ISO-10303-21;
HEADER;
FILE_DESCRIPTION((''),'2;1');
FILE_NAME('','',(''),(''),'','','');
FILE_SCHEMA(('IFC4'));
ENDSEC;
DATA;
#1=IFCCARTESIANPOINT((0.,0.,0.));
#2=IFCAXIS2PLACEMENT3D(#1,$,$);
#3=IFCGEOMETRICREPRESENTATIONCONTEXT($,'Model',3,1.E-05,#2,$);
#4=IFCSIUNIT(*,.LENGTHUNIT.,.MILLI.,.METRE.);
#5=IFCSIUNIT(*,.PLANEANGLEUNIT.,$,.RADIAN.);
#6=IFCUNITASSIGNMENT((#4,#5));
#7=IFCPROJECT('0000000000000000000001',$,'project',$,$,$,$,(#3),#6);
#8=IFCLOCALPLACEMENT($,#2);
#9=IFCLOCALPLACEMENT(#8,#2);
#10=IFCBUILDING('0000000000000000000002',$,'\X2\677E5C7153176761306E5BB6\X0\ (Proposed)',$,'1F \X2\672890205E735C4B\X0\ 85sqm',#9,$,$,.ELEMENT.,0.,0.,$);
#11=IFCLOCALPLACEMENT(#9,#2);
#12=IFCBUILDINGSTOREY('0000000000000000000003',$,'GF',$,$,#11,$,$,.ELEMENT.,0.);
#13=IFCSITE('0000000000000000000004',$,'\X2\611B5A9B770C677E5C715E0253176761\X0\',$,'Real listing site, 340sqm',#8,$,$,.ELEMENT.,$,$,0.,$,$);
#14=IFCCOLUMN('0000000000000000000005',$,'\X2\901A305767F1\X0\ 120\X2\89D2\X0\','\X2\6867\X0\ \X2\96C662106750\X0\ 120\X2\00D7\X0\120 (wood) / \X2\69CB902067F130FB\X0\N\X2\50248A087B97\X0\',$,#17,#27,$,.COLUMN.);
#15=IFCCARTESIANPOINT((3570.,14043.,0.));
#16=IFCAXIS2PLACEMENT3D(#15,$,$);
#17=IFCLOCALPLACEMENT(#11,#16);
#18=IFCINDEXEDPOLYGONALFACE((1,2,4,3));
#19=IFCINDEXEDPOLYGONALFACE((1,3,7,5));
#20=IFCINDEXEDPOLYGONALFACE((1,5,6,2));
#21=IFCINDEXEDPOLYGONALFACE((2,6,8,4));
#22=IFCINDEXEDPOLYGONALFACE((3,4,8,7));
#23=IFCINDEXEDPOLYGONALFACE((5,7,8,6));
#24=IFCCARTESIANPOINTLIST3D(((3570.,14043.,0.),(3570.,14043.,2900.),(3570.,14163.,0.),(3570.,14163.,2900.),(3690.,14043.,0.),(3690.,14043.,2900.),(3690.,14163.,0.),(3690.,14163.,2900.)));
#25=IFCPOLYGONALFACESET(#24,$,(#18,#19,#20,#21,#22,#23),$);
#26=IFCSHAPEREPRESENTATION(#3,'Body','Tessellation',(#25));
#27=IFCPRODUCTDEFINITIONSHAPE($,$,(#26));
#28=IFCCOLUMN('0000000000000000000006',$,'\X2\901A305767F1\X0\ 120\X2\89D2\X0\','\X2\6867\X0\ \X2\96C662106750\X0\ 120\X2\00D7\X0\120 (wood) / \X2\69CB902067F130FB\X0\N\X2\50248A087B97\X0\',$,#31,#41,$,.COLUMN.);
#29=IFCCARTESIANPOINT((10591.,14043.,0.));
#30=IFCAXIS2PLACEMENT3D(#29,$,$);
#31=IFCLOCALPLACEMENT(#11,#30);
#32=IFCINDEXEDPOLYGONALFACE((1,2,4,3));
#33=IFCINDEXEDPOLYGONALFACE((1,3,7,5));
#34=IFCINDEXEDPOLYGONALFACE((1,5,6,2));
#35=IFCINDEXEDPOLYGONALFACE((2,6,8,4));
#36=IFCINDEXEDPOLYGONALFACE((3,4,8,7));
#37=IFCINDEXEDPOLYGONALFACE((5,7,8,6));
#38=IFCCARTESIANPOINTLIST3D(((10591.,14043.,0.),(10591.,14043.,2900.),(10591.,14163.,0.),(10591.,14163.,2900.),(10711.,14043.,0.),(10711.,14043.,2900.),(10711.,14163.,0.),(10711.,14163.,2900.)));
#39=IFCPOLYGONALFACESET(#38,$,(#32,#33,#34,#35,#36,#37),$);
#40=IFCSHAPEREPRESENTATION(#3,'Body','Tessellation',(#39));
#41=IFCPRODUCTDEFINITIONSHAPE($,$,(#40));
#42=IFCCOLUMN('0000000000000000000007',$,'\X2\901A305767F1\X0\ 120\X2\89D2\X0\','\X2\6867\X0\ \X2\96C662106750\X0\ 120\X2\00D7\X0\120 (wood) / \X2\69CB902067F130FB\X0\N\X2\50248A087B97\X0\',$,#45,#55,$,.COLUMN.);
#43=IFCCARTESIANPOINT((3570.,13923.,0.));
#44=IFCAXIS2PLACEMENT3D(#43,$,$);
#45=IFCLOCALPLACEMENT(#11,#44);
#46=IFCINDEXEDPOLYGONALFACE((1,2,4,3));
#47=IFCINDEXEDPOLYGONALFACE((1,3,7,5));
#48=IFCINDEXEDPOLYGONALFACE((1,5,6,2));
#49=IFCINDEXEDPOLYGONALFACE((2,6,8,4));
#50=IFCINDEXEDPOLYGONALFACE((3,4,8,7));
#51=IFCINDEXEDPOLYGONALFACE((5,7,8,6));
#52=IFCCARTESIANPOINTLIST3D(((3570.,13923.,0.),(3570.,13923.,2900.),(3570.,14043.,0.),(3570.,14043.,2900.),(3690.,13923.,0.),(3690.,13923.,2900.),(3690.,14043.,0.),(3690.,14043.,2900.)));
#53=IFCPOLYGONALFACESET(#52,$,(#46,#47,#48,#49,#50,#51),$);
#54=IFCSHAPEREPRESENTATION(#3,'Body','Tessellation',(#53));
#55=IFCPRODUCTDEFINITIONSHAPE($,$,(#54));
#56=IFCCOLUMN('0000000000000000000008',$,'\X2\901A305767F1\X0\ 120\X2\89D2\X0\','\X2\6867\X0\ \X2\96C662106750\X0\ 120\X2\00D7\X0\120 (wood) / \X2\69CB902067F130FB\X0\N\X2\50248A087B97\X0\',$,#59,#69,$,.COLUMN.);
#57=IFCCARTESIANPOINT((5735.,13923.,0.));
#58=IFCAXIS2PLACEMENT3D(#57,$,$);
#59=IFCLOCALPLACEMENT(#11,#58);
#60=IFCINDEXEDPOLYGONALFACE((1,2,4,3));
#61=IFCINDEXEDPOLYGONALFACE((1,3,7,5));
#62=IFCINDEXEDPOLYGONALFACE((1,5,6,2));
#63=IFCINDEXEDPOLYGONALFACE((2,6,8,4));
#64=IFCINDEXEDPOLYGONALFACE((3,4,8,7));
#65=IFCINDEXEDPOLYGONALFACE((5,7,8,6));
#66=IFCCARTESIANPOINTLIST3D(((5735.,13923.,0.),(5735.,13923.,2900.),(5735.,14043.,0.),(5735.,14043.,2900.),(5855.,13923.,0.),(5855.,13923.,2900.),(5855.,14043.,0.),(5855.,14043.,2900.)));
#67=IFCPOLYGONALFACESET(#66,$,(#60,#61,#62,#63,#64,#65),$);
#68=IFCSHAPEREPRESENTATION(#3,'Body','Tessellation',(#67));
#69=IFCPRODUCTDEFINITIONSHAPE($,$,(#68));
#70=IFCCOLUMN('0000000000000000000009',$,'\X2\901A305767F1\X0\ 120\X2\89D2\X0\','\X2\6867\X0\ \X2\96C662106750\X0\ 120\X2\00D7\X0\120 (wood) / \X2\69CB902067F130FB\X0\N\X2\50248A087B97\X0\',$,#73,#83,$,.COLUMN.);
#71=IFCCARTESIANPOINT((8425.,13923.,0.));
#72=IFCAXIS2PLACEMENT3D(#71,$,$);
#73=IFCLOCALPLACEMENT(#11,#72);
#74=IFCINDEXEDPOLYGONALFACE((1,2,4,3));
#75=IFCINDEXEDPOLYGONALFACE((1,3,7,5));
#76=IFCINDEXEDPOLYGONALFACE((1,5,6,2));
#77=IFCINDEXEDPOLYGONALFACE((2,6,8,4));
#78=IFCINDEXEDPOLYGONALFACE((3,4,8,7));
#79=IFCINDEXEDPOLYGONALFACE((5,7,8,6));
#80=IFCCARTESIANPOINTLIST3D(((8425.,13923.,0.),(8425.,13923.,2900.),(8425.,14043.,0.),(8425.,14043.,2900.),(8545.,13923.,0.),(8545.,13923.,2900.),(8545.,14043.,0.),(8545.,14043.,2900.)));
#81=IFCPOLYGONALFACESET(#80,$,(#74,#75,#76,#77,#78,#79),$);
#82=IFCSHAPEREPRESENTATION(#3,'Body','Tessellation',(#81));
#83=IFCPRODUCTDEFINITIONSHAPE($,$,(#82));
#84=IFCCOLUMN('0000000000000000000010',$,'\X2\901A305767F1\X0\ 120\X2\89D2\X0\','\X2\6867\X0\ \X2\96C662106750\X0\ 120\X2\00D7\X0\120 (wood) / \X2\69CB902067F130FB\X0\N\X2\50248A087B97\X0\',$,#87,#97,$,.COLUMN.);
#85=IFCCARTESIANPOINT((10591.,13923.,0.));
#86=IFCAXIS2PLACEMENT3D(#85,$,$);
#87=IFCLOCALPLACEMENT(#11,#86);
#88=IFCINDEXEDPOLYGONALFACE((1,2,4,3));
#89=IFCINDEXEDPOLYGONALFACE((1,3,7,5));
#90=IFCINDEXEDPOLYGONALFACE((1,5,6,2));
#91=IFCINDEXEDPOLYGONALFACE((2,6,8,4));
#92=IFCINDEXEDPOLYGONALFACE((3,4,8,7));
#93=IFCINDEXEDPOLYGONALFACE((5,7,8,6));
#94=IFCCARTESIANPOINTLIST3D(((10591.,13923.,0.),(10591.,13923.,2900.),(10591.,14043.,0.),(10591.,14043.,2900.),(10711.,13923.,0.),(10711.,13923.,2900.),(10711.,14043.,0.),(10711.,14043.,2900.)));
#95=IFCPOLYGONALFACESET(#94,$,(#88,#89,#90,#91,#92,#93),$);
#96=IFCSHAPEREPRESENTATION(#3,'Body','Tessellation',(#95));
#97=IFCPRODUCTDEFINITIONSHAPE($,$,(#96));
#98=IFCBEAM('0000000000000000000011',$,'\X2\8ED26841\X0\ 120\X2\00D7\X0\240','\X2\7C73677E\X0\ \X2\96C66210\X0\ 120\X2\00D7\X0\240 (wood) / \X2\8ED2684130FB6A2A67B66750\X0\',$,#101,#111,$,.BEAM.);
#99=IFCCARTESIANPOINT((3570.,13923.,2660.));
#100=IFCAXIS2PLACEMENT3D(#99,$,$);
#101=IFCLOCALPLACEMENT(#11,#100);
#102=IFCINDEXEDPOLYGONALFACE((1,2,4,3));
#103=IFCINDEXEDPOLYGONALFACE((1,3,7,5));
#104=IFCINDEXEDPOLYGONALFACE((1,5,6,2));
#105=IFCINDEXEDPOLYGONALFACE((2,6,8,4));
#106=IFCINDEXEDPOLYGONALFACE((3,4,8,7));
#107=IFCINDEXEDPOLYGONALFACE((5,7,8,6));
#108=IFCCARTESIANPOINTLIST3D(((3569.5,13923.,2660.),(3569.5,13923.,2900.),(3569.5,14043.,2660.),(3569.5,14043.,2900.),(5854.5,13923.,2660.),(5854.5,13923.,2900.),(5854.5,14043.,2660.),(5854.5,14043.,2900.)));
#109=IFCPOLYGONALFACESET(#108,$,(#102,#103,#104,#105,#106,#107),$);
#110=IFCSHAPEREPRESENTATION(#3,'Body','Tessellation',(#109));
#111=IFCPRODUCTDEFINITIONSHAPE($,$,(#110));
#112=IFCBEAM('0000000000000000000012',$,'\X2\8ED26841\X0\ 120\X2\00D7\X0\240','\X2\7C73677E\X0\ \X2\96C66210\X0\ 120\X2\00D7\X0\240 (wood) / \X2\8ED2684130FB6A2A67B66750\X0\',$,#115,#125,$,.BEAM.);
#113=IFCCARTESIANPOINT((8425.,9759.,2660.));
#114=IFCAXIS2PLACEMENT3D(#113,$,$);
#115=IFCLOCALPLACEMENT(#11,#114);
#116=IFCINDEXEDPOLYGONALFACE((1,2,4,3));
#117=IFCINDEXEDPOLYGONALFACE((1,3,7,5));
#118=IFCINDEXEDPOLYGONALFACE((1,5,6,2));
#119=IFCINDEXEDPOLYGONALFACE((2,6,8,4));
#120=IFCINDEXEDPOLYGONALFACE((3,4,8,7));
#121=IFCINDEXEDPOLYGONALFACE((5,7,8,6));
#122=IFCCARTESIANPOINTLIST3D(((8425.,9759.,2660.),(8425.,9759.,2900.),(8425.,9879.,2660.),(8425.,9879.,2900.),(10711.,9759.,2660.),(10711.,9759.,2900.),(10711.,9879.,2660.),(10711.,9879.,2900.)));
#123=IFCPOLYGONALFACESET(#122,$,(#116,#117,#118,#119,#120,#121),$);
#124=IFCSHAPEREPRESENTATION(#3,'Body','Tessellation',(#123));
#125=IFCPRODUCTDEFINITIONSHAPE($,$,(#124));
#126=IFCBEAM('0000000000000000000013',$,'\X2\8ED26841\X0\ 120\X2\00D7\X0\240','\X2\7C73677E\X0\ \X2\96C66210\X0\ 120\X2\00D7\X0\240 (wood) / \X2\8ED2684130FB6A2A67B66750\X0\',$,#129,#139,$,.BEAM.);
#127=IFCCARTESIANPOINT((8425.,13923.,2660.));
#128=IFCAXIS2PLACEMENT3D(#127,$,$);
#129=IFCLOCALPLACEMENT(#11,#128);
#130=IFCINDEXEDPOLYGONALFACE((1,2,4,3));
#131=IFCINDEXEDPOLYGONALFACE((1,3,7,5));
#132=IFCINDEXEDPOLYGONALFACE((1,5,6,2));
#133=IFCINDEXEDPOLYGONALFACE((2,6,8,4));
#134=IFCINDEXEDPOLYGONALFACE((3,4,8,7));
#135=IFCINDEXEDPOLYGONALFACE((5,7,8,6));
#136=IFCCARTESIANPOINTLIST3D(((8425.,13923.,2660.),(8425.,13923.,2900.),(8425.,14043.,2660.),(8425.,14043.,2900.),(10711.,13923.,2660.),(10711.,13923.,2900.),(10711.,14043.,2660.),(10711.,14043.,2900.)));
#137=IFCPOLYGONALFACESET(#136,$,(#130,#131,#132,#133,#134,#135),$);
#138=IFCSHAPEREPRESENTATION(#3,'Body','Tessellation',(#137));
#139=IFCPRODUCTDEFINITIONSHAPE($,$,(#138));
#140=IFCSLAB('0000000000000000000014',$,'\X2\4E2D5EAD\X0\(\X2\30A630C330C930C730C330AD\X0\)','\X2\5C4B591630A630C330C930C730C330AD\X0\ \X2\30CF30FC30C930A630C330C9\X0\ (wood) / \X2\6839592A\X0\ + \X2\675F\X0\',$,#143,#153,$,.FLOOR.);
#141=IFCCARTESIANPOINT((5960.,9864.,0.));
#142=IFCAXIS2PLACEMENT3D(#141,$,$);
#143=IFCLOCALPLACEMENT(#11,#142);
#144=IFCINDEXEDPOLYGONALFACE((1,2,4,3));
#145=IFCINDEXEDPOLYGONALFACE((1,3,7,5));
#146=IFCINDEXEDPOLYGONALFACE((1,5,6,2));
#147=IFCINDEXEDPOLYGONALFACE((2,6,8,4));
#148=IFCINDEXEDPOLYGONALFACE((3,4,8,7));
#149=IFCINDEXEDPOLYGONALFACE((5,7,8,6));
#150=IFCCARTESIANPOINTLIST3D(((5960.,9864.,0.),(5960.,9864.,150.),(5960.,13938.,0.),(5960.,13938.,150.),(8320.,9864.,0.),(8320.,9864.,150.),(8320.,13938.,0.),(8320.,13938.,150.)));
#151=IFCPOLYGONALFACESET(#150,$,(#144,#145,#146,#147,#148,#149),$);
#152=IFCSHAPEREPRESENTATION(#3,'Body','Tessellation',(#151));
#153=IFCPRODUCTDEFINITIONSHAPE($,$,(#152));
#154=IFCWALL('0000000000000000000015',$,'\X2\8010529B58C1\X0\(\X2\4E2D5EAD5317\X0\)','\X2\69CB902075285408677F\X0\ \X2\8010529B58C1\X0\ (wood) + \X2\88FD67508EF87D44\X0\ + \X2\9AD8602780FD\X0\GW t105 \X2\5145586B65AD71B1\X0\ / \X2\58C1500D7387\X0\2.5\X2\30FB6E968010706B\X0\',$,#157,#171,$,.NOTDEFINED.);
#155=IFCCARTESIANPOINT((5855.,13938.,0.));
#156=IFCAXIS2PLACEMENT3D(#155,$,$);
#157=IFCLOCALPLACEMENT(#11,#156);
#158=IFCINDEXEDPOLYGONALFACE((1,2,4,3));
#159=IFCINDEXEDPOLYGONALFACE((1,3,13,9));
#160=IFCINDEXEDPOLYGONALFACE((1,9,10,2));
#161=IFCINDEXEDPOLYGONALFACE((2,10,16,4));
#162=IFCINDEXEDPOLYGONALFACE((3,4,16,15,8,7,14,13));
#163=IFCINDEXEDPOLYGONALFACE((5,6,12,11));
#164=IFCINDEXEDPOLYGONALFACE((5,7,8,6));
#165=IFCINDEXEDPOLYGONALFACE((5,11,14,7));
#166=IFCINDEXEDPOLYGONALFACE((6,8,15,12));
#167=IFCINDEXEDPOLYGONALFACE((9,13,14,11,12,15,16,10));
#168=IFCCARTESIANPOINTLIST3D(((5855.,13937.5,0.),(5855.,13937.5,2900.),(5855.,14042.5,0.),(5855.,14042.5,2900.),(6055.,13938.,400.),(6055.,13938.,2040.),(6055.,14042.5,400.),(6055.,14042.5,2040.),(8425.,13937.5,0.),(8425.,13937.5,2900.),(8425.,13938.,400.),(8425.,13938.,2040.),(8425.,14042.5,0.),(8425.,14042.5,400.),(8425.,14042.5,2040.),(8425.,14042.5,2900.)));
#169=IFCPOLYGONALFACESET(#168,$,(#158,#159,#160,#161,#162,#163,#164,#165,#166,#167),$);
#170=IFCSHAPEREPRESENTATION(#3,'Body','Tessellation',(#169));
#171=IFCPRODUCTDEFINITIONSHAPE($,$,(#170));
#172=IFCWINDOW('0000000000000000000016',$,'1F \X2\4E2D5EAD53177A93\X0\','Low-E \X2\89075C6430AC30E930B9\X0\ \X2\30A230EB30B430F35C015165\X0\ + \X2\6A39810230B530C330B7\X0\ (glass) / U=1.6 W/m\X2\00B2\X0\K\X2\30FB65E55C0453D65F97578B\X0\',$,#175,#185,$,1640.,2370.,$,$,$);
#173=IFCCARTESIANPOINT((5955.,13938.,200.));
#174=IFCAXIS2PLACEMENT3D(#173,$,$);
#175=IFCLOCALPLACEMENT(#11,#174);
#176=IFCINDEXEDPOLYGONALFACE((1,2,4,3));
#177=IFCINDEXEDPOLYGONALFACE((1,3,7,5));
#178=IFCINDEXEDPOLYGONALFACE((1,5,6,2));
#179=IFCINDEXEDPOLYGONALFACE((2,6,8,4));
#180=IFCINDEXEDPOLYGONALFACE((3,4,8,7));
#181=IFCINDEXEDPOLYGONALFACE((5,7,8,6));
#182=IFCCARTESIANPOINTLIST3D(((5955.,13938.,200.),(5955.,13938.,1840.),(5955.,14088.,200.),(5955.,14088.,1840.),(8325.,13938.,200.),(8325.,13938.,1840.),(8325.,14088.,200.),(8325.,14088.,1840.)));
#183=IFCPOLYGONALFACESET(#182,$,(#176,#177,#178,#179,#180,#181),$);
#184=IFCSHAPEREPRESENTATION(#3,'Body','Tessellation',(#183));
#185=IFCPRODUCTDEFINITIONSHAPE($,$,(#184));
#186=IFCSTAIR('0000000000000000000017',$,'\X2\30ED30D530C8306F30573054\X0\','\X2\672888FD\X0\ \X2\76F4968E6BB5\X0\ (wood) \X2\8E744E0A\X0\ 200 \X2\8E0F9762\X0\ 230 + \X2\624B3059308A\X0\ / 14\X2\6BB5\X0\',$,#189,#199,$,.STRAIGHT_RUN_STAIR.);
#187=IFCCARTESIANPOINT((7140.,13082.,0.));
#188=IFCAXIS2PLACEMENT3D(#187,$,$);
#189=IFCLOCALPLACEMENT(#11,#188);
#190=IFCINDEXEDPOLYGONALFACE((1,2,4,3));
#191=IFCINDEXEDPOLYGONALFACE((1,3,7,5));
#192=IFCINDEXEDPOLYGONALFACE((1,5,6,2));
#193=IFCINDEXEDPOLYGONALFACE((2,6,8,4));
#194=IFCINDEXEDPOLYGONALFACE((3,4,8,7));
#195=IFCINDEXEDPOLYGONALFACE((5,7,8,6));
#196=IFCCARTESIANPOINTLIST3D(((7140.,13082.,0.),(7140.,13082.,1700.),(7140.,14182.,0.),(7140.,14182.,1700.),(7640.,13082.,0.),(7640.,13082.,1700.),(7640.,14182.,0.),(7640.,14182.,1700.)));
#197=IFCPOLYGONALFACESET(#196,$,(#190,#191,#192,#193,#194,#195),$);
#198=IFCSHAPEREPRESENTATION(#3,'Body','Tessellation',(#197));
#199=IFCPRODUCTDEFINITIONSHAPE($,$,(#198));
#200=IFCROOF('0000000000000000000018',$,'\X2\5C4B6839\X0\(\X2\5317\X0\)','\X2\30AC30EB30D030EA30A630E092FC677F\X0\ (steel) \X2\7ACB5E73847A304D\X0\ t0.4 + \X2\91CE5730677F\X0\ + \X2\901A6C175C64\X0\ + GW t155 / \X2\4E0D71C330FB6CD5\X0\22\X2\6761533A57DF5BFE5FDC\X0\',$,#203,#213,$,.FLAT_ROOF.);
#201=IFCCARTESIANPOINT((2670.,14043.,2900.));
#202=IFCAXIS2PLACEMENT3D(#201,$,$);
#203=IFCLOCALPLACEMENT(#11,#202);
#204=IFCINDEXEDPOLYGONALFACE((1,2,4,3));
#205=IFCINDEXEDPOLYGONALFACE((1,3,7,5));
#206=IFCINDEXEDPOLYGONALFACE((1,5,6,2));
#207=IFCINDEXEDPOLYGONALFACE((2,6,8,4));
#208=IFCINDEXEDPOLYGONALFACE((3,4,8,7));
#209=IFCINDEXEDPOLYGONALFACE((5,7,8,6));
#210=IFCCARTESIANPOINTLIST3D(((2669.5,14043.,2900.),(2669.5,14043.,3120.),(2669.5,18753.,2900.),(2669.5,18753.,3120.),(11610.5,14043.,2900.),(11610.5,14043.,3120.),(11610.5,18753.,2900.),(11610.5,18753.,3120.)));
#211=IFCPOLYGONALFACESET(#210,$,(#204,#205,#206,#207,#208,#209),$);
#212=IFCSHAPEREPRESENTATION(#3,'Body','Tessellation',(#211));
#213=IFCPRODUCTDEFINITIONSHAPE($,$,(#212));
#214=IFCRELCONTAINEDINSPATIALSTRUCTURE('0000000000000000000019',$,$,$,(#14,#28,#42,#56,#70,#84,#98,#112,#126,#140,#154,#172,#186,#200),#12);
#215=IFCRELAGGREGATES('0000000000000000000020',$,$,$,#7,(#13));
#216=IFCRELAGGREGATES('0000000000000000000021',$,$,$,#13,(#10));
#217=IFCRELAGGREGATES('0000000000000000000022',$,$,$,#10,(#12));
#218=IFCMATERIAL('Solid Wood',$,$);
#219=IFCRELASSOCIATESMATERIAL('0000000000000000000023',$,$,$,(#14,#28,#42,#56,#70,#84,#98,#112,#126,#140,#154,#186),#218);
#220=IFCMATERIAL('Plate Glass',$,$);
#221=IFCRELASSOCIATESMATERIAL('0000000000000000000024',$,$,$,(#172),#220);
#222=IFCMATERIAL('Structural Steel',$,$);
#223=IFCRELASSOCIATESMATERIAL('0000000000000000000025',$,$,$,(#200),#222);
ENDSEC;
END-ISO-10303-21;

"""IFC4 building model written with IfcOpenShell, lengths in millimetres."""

from ifc_helpers import new_model, si_unit, frame, frame_2d, origin, place, context, project, spatial, rectangle, extrude, material, element, fill, save


model = new_model("IFC4")

# Units and contexts
model_context = context("Model", 3, precision=1e-05, world=origin())
ifc_project = project(units=[si_unit("LENGTHUNIT", "METRE", prefix="MILLI"), si_unit("PLANEANGLEUNIT", "RADIAN")], contexts=[model_context])

# Site, building, storey
site_placement = place(None, origin())
site = spatial("IfcSite", under=ifc_project, at=site_placement, Name="愛媛県松山市北条", ObjectType="Real listing site, 340sqm", CompositionType="ELEMENT", RefElevation=0.0)
building_placement = place(site_placement, origin())
building = spatial("IfcBuilding", under=site, at=building_placement, Name="松山北条の家 (Proposed)", ObjectType="1F 木造平屋 85sqm", CompositionType="ELEMENT", ElevationOfRefHeight=0.0, ElevationOfTerrain=0.0)
storey_placement = place(building_placement, origin())
storey = spatial("IfcBuildingStorey", under=building, at=storey_placement, Name="GF", CompositionType="ELEMENT", Elevation=0.0)

# Columns
ifc_material_1 = material(Name="Solid Wood")
column_1_placement = place(storey_placement, frame((3570.0, 14043.0, 0.0)))
element("IfcColumn", 1, at=column_1_placement, inside=storey, material=ifc_material_1, Name="通し柱 120角", Description="桧 集成材 120×120 (wood) / 構造柱・N値計算", PredefinedType="COLUMN", context=model_context, shape_type="SweptSolid", body=[
    extrude(rectangle(XDim=120.0, YDim=120.0, at=frame_2d((60.0, 60.0))), frame((3570.0, 14043.0, 0.0)), (0.0, 0.0, 1.0), 2900.0),
])
column_2_placement = place(storey_placement, frame((10591.0, 14043.0, 0.0)))
element("IfcColumn", 2, at=column_2_placement, inside=storey, material=ifc_material_1, Name="通し柱 120角", Description="桧 集成材 120×120 (wood) / 構造柱・N値計算", PredefinedType="COLUMN", context=model_context, shape_type="SweptSolid", body=[
    extrude(rectangle(XDim=120.0, YDim=120.0, at=frame_2d((60.0, 60.0))), frame((10591.0, 14043.0, 0.0)), (0.0, 0.0, 1.0), 2900.0),
])
column_3_placement = place(storey_placement, frame((3570.0, 13923.0, 0.0)))
element("IfcColumn", 3, at=column_3_placement, inside=storey, material=ifc_material_1, Name="通し柱 120角", Description="桧 集成材 120×120 (wood) / 構造柱・N値計算", PredefinedType="COLUMN", context=model_context, shape_type="SweptSolid", body=[
    extrude(rectangle(XDim=120.0, YDim=120.0, at=frame_2d((60.0, 60.0))), frame((3570.0, 13923.0, 0.0)), (0.0, 0.0, 1.0), 2900.0),
])
column_4_placement = place(storey_placement, frame((5735.0, 13923.0, 0.0)))
element("IfcColumn", 4, at=column_4_placement, inside=storey, material=ifc_material_1, Name="通し柱 120角", Description="桧 集成材 120×120 (wood) / 構造柱・N値計算", PredefinedType="COLUMN", context=model_context, shape_type="SweptSolid", body=[
    extrude(rectangle(XDim=120.0, YDim=120.0, at=frame_2d((60.0, 60.0))), frame((5735.0, 13923.0, 0.0)), (0.0, 0.0, 1.0), 2900.0),
])
column_5_placement = place(storey_placement, frame((8425.0, 13923.0, 0.0)))
element("IfcColumn", 5, at=column_5_placement, inside=storey, material=ifc_material_1, Name="通し柱 120角", Description="桧 集成材 120×120 (wood) / 構造柱・N値計算", PredefinedType="COLUMN", context=model_context, shape_type="SweptSolid", body=[
    extrude(rectangle(XDim=120.0, YDim=120.0, at=frame_2d((60.0, 60.0))), frame((8425.0, 13923.0, 0.0)), (0.0, 0.0, 1.0), 2900.0),
])
column_6_placement = place(storey_placement, frame((10591.0, 13923.0, 0.0)))
element("IfcColumn", 6, at=column_6_placement, inside=storey, material=ifc_material_1, Name="通し柱 120角", Description="桧 集成材 120×120 (wood) / 構造柱・N値計算", PredefinedType="COLUMN", context=model_context, shape_type="SweptSolid", body=[
    extrude(rectangle(XDim=120.0, YDim=120.0, at=frame_2d((60.0, 60.0))), frame((10591.0, 13923.0, 0.0)), (0.0, 0.0, 1.0), 2900.0),
])

# Beams
beam_1_placement = place(storey_placement, frame((3570.0, 13923.0, 2660.0)))
element("IfcBeam", 7, at=beam_1_placement, inside=storey, material=ifc_material_1, Name="軒桁 120×240", Description="米松 集成 120×240 (wood) / 軒桁・横架材", PredefinedType="BEAM", context=model_context, shape_type="SweptSolid", body=[
    extrude(rectangle(XDim=2285.0, YDim=120.0, at=frame_2d((1142.0, 60.0))), frame((3570.0, 13923.0, 2660.0)), (0.0, 0.0, 1.0), 240.0),
])
beam_2_placement = place(storey_placement, frame((8425.0, 9759.0, 2660.0)))
element("IfcBeam", 8, at=beam_2_placement, inside=storey, material=ifc_material_1, Name="軒桁 120×240", Description="米松 集成 120×240 (wood) / 軒桁・横架材", PredefinedType="BEAM", context=model_context, shape_type="SweptSolid", body=[
    extrude(rectangle(XDim=2286.0, YDim=120.0, at=frame_2d((1143.0, 60.0))), frame((8425.0, 9759.0, 2660.0)), (0.0, 0.0, 1.0), 240.0),
])
beam_3_placement = place(storey_placement, frame((8425.0, 13923.0, 2660.0)))
element("IfcBeam", 9, at=beam_3_placement, inside=storey, material=ifc_material_1, Name="軒桁 120×240", Description="米松 集成 120×240 (wood) / 軒桁・横架材", PredefinedType="BEAM", context=model_context, shape_type="SweptSolid", body=[
    extrude(rectangle(XDim=2286.0, YDim=120.0, at=frame_2d((1143.0, 60.0))), frame((8425.0, 13923.0, 2660.0)), (0.0, 0.0, 1.0), 240.0),
])

# Slab
slab_1_placement = place(storey_placement, frame((5960.0, 9864.0, 0.0)))
element("IfcSlab", 10, at=slab_1_placement, inside=storey, material=ifc_material_1, Name="中庭(ウッドデッキ)", Description="屋外ウッドデッキ ハードウッド (wood) / 根太 + 束", PredefinedType="FLOOR", context=model_context, shape_type="SweptSolid", body=[
    extrude(rectangle(XDim=2360.0, YDim=4074.0, at=frame_2d((1180.0, 2037.0))), frame((5960.0, 9864.0, 0.0)), (0.0, 0.0, 1.0), 150.0),
])

# Wall, opening, window
wall_placement = place(storey_placement, frame((5855.0, 13938.0, 0.0)))
wall = element("IfcWall", 11, at=wall_placement, inside=storey, material=ifc_material_1, Name="耐力壁(中庭北)", Description="構造用合板 耐力壁 (wood) + 製材軸組 + 高性能GW t105 充填断熱 / 壁倍率2.5・準耐火", PredefinedType="NOTDEFINED", context=model_context, shape_type="SweptSolid", body=[
    extrude(rectangle(XDim=2570.0, YDim=105.0, at=frame_2d((1285.0, 52.0))), frame((5855.0, 13938.0, 0.0)), (0.0, 0.0, 1.0), 2900.0),
])
opening_placement = place(storey_placement, frame((5955.0, 13938.0, 200.0)))
opening = element("IfcOpeningElement", 12, at=opening_placement, cuts=wall, PredefinedType="NOTDEFINED", context=model_context, shape_type="SweptSolid", body=[
    extrude(rectangle(XDim=2370.0, YDim=150.0, at=frame_2d((1185.0, 75.0))), frame((5955.0, 13938.0, 200.0)), (0.0, 0.0, 1.0), 1640.0),
])
ifc_material_2 = material(Name="Plate Glass")
window_placement = place(storey_placement, frame((5955.0, 13938.0, 200.0)))
window = element("IfcWindow", 13, at=window_placement, inside=storey, material=ifc_material_2, Name="1F 中庭北窓", Description="Low-E 複層ガラス アルゴン封入 + 樹脂サッシ (glass) / U=1.6 W/m²K・日射取得型", OverallHeight=1640.0, OverallWidth=2370.0, context=model_context, shape_type="SweptSolid", body=[
    extrude(rectangle(XDim=2370.0, YDim=150.0, at=frame_2d((1185.0, 75.0))), frame((5955.0, 13938.0, 200.0)), (0.0, 0.0, 1.0), 1640.0),
])
fill(opening, window)

# Stair
stair_placement = place(storey_placement, frame((7140.0, 13082.0, 0.0)))
element("IfcStair", 14, at=stair_placement, inside=storey, material=ifc_material_1, Name="ロフトはしご", Description="木製 直階段 (wood) 蹴上 200 踏面 230 + 手すり / 14段", PredefinedType="STRAIGHT_RUN_STAIR", context=model_context, shape_type="SweptSolid", body=[
    extrude(rectangle(XDim=500.0, YDim=1100.0, at=frame_2d((250.0, 550.0))), frame((7140.0, 13082.0, 0.0)), (0.0, 0.0, 1.0), 1700.0),
])

# Roof
ifc_material_3 = material(Name="Structural Steel")
roof_placement = place(storey_placement, frame((2670.0, 14043.0, 2900.0)))
element("IfcRoof", 15, at=roof_placement, inside=storey, material=ifc_material_3, Name="屋根(北)", Description="ガルバリウム鋼板 (steel) 立平葺き t0.4 + 野地板 + 通気層 + GW t155 / 不燃・法22条区域対応", PredefinedType="FLAT_ROOF", context=model_context, shape_type="SweptSolid", body=[
    extrude(rectangle(XDim=8941.0, YDim=4710.0, at=frame_2d((4470.0, 2355.0))), frame((2670.0, 14043.0, 2900.0)), (0.0, 0.0, 1.0), 220.0),
])

save(model, "model.ifc")
